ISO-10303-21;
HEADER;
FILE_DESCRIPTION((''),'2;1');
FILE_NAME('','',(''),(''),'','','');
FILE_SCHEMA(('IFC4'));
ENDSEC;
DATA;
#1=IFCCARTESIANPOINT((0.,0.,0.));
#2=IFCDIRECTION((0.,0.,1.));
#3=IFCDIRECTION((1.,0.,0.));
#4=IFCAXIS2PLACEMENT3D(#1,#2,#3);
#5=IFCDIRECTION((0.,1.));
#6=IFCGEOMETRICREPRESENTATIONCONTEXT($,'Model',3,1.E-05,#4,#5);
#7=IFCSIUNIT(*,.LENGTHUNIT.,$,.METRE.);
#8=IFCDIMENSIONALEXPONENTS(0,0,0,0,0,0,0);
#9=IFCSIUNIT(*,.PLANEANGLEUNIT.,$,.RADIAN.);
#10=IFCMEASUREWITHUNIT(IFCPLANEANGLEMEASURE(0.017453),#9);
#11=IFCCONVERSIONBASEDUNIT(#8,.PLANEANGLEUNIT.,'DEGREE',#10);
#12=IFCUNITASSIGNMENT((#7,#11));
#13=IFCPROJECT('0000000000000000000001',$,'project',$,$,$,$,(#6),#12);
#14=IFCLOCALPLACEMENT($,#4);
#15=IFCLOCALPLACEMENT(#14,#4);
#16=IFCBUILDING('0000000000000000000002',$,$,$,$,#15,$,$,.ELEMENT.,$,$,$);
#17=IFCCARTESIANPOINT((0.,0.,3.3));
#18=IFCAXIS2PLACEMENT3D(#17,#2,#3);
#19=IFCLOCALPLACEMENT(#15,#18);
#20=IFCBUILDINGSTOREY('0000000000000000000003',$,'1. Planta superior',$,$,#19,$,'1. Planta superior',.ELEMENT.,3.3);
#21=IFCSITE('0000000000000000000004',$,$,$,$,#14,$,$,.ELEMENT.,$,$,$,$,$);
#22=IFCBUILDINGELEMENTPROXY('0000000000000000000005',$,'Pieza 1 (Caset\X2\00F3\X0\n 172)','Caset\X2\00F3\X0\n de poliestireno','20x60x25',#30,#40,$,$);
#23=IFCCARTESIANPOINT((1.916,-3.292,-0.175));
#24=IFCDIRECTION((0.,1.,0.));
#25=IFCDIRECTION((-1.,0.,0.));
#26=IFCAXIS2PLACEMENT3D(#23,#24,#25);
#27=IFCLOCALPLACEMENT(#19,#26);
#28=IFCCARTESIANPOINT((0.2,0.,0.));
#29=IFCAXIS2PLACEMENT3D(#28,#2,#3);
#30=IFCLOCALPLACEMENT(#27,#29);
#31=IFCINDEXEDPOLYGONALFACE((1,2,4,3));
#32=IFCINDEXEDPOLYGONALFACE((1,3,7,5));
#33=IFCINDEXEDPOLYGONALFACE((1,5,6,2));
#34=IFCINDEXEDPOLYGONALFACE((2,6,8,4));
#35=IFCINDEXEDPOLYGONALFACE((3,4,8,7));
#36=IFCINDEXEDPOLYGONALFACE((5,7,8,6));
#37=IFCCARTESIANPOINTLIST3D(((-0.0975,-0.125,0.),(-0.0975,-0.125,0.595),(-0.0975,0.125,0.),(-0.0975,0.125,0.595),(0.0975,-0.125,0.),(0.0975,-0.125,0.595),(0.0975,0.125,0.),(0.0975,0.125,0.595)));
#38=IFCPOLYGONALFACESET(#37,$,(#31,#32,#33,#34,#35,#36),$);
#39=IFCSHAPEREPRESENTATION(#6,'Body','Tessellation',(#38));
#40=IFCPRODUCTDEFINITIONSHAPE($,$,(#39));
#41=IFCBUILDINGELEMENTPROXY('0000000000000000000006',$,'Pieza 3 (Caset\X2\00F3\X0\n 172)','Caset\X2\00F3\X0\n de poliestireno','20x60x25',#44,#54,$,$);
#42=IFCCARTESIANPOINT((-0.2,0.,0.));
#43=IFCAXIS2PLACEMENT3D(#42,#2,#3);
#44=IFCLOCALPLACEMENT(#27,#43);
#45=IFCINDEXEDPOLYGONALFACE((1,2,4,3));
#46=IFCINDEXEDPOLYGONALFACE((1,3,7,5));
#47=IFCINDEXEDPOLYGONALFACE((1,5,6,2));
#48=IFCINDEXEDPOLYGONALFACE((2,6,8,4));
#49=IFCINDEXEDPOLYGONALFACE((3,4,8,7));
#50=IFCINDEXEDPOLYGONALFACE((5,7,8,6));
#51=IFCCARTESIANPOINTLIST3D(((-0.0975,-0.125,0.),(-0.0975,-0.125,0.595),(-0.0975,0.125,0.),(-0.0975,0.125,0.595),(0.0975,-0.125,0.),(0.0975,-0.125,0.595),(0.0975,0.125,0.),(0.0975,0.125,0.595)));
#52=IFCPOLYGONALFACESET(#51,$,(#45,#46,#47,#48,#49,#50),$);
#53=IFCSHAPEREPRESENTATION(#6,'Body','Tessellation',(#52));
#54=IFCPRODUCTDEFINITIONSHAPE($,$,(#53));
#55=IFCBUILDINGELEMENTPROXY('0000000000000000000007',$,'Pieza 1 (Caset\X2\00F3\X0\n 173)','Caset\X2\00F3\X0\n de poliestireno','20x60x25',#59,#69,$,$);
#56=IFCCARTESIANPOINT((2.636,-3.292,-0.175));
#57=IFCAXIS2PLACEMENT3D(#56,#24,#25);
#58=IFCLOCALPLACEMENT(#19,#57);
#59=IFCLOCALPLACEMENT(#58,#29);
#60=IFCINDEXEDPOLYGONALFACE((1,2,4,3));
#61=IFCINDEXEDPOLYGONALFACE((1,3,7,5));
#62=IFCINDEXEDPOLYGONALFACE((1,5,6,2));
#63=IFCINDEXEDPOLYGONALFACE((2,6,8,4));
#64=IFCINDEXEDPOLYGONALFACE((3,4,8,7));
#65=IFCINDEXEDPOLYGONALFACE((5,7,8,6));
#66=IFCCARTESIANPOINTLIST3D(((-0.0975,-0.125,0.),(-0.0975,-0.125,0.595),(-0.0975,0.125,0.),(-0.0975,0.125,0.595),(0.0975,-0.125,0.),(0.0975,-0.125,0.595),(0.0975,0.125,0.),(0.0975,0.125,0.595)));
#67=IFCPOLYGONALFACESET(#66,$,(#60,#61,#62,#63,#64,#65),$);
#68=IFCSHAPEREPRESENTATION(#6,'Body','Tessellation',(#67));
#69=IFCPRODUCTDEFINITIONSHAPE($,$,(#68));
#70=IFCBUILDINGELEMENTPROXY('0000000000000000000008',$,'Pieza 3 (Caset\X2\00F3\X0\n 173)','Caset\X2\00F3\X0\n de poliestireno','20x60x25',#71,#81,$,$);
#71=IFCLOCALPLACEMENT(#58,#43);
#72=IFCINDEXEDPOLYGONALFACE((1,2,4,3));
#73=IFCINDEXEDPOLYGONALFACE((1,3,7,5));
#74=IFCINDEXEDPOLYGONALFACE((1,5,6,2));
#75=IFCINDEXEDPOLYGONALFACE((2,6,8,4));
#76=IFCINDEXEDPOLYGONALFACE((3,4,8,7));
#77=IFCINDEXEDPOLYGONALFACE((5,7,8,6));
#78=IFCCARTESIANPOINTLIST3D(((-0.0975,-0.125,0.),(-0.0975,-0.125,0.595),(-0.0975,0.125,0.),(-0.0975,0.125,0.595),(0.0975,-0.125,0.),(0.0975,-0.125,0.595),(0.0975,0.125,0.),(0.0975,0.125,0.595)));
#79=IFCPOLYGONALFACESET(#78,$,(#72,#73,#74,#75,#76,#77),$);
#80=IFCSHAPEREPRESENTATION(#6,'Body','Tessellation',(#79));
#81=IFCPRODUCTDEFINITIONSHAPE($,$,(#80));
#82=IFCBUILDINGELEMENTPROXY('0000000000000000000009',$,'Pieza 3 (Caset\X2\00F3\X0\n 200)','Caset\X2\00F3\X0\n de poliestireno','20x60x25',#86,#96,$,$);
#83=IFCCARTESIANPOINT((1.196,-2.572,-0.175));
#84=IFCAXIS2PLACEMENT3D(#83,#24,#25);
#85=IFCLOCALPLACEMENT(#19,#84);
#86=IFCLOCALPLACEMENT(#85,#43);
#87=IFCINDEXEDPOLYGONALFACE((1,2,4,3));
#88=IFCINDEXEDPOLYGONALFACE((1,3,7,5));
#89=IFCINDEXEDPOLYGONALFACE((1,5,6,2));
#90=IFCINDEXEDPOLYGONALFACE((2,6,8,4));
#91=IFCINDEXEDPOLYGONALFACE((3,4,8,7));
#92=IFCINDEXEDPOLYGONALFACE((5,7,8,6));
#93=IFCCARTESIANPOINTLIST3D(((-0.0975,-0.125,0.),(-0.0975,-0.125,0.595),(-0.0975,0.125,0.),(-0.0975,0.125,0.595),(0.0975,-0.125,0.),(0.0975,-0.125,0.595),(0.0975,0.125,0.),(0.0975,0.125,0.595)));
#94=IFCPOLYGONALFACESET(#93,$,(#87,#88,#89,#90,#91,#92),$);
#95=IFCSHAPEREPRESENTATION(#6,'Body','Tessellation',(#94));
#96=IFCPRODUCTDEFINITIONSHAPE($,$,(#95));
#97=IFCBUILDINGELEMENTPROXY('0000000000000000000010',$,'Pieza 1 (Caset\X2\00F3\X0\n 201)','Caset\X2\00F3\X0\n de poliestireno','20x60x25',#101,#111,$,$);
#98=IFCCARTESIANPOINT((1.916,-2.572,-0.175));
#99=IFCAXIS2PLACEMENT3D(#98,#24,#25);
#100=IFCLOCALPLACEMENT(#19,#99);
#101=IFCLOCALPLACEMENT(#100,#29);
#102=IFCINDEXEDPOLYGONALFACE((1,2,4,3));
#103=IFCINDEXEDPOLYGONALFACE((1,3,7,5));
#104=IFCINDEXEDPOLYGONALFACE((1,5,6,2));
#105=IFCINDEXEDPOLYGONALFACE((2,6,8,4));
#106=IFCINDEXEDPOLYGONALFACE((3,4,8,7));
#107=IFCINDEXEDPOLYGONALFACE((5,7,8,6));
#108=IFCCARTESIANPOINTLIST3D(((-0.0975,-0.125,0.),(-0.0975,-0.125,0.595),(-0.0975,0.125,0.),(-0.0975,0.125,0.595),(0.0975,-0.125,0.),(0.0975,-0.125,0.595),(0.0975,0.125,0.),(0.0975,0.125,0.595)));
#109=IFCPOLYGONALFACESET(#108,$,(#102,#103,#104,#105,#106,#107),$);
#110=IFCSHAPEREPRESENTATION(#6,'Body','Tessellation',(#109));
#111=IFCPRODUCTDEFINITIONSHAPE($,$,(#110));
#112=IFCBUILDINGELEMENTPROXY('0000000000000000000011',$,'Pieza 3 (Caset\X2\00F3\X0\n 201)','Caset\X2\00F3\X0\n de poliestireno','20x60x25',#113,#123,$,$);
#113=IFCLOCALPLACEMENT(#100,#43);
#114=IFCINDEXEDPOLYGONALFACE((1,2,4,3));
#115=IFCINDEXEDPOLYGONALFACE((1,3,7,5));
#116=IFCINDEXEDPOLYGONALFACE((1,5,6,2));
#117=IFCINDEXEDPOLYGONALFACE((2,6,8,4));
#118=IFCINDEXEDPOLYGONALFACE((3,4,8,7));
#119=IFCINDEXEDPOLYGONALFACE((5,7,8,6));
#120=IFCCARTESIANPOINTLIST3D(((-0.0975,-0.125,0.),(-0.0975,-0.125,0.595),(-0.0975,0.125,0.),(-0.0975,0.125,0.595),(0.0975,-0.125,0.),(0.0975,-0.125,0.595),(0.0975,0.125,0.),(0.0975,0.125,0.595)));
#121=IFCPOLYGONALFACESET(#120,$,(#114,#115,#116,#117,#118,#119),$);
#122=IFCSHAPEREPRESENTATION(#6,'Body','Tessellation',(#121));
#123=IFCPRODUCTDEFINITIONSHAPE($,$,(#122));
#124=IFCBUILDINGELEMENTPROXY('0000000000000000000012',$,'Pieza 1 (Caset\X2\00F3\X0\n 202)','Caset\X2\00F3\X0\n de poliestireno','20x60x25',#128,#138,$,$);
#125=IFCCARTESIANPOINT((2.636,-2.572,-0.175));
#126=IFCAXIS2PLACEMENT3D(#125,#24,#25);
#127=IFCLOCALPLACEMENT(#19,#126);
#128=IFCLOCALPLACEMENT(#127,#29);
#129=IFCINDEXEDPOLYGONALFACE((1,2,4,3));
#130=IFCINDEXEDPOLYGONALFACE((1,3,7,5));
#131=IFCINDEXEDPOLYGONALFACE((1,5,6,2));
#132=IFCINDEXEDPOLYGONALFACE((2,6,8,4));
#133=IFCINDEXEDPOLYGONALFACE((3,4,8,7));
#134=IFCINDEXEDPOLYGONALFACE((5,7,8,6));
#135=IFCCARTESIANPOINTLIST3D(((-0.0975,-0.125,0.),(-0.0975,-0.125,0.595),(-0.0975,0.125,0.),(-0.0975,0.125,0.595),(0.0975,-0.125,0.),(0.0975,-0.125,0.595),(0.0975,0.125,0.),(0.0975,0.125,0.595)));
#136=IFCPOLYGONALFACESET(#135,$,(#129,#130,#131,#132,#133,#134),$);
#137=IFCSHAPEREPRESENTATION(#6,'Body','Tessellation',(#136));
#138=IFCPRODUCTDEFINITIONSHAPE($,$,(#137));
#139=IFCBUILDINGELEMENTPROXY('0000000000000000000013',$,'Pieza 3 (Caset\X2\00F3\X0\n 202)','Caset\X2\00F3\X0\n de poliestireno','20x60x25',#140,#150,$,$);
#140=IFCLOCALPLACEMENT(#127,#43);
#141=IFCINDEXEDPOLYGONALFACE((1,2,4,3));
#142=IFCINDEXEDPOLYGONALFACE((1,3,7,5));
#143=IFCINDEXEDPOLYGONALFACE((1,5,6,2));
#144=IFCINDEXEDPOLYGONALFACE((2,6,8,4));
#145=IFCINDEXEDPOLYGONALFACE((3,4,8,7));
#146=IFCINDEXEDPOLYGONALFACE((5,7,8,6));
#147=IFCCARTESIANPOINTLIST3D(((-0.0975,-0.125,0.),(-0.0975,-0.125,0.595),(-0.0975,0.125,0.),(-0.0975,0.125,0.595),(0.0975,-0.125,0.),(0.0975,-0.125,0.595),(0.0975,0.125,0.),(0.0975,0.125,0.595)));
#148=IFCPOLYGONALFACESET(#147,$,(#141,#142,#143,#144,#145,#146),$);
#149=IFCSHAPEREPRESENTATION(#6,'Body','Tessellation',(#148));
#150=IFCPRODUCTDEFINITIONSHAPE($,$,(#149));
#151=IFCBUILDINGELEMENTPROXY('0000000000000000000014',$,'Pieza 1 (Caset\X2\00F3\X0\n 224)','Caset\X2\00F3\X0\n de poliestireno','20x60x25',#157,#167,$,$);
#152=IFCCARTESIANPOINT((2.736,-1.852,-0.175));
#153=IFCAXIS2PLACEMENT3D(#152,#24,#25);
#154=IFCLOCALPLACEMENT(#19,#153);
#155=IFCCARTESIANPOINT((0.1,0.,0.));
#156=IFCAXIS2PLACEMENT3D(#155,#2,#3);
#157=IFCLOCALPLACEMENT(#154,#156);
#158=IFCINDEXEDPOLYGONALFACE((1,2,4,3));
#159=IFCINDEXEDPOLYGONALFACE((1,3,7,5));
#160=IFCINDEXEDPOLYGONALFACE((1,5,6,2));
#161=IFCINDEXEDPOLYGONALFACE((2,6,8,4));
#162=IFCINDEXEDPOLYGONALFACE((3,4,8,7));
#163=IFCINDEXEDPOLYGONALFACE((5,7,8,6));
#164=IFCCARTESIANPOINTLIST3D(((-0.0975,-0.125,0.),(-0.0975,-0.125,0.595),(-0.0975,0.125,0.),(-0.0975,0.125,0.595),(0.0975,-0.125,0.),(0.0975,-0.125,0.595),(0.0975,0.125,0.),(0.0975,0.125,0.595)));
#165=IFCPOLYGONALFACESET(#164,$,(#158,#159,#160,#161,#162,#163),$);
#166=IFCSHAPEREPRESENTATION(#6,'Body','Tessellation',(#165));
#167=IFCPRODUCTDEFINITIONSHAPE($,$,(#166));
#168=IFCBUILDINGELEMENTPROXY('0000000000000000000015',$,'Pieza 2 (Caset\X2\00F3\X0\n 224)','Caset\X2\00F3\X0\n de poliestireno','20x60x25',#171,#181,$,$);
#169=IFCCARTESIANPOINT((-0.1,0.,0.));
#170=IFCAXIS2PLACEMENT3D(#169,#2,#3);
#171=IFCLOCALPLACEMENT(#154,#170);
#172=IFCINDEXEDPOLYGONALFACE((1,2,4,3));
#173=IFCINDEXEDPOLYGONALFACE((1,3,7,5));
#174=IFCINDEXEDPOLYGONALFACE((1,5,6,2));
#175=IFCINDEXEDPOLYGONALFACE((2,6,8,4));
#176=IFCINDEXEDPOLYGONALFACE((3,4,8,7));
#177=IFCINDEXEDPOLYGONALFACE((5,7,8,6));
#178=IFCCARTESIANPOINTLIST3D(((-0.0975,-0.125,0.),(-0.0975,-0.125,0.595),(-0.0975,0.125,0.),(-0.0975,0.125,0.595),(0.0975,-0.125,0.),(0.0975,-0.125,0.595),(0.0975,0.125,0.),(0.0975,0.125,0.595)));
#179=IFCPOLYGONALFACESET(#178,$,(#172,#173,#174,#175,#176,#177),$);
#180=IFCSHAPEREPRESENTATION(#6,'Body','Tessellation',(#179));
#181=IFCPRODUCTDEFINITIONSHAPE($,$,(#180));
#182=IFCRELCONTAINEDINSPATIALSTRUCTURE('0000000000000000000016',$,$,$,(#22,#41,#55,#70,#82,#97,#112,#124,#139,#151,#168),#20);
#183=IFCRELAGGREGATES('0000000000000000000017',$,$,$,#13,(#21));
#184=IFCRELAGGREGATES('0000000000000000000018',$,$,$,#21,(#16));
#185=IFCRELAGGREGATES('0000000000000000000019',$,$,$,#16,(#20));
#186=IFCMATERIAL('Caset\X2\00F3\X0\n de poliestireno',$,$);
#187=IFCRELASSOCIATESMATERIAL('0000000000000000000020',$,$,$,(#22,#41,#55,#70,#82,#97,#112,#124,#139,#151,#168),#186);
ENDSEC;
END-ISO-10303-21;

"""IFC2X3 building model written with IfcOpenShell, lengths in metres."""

from ifc_helpers import new_model, entity, si_unit, converted_unit, direction, frame, origin_with_axes, origin_2d_with_axis, place, context, project, spatial, rectangle, extrude, source, transform, mapped, material, element, save


model = new_model("IFC2X3")

# Units and contexts
model_context = context("Model", 3, precision=1e-05, world=origin_with_axes(), true_north=direction((0.0, 1.0)))
ifc_project = project(units=[si_unit("LENGTHUNIT", "METRE"), converted_unit("PLANEANGLEUNIT", "DEGREE", entity("IfcPlaneAngleMeasure", 0.017453), si_unit("PLANEANGLEUNIT", "RADIAN"), dimensions=[0, 0, 0, 0, 0, 0, 0])], contexts=[model_context])

# Site, building, storey
site_placement = place(None, origin_with_axes())
site = spatial("IfcSite", under=ifc_project, at=site_placement, CompositionType="ELEMENT")
building_placement = place(site_placement, origin_with_axes())
building = spatial("IfcBuilding", under=site, at=building_placement, CompositionType="ELEMENT")
storey_placement = place(building_placement, frame((0.0, 0.0, 3.3), z_axis=(0.0, 0.0, 1.0), x_axis=(1.0, 0.0, 0.0)))
storey = spatial("IfcBuildingStorey", under=building, at=storey_placement, Name="1. Planta superior", LongName="1. Planta superior", CompositionType="ELEMENT", Elevation=3.3)

# Building element proxies
ifc_material_1 = material(Name="Casetón de poliestireno")
shared_shape = source(origin_with_axes(), model_context, "Body", "SweptSolid", [
    extrude(rectangle(XDim=0.195, YDim=0.25, at=origin_2d_with_axis()), origin_with_axes(), (0.0, 0.0, 1.0), 0.595),
])
placement_1 = place(storey_placement, frame((1.916, -3.292, -0.175), z_axis=(0.0, 1.0, 0.0), x_axis=(-1.0, 0.0, 0.0)))
for number, where, z_axis, x_axis, name in (
    (1, (0.2, 0.0, 0.0), (0.0, 0.0, 1.0), (1.0, 0.0, 0.0), "Pieza 1 (Casetón 172)"),
    (2, (-0.2, 0.0, 0.0), (0.0, 0.0, 1.0), (1.0, 0.0, 0.0), "Pieza 3 (Casetón 172)"),
):
    element("IfcBuildingElementProxy", number, at=place(placement_1, frame(where, z_axis=z_axis, x_axis=x_axis)), inside=storey, material=ifc_material_1, Name=name, Description="Casetón de poliestireno", ObjectType="20x60x25", context=model_context, shape_type="MappedRepresentation", body=[
        mapped(shared_shape, transform((0.0, 0.0, 0.0), x_axis=(1.0, 0.0, 0.0), y_axis=(0.0, 1.0, 0.0), z_axis=(0.0, 0.0, 1.0))),
    ])
placement_2 = place(storey_placement, frame((2.636, -3.292, -0.175), z_axis=(0.0, 1.0, 0.0), x_axis=(-1.0, 0.0, 0.0)))
for number, where, z_axis, x_axis, name in (
    (3, (0.2, 0.0, 0.0), (0.0, 0.0, 1.0), (1.0, 0.0, 0.0), "Pieza 1 (Casetón 173)"),
    (4, (-0.2, 0.0, 0.0), (0.0, 0.0, 1.0), (1.0, 0.0, 0.0), "Pieza 3 (Casetón 173)"),
):
    element("IfcBuildingElementProxy", number, at=place(placement_2, frame(where, z_axis=z_axis, x_axis=x_axis)), inside=storey, material=ifc_material_1, Name=name, Description="Casetón de poliestireno", ObjectType="20x60x25", context=model_context, shape_type="MappedRepresentation", body=[
        mapped(shared_shape, transform((0.0, 0.0, 0.0), x_axis=(1.0, 0.0, 0.0), y_axis=(0.0, 1.0, 0.0), z_axis=(0.0, 0.0, 1.0))),
    ])
placement_3 = place(storey_placement, frame((1.196, -2.572, -0.175), z_axis=(0.0, 1.0, 0.0), x_axis=(-1.0, 0.0, 0.0)))
for number, where, z_axis, x_axis, name in (
    (5, (-0.2, 0.0, 0.0), (0.0, 0.0, 1.0), (1.0, 0.0, 0.0), "Pieza 3 (Casetón 200)"),
):
    element("IfcBuildingElementProxy", number, at=place(placement_3, frame(where, z_axis=z_axis, x_axis=x_axis)), inside=storey, material=ifc_material_1, Name=name, Description="Casetón de poliestireno", ObjectType="20x60x25", context=model_context, shape_type="MappedRepresentation", body=[
        mapped(shared_shape, transform((0.0, 0.0, 0.0), x_axis=(1.0, 0.0, 0.0), y_axis=(0.0, 1.0, 0.0), z_axis=(0.0, 0.0, 1.0))),
    ])
placement_4 = place(storey_placement, frame((1.916, -2.572, -0.175), z_axis=(0.0, 1.0, 0.0), x_axis=(-1.0, 0.0, 0.0)))
for number, where, z_axis, x_axis, name in (
    (6, (0.2, 0.0, 0.0), (0.0, 0.0, 1.0), (1.0, 0.0, 0.0), "Pieza 1 (Casetón 201)"),
    (7, (-0.2, 0.0, 0.0), (0.0, 0.0, 1.0), (1.0, 0.0, 0.0), "Pieza 3 (Casetón 201)"),
):
    element("IfcBuildingElementProxy", number, at=place(placement_4, frame(where, z_axis=z_axis, x_axis=x_axis)), inside=storey, material=ifc_material_1, Name=name, Description="Casetón de poliestireno", ObjectType="20x60x25", context=model_context, shape_type="MappedRepresentation", body=[
        mapped(shared_shape, transform((0.0, 0.0, 0.0), x_axis=(1.0, 0.0, 0.0), y_axis=(0.0, 1.0, 0.0), z_axis=(0.0, 0.0, 1.0))),
    ])
placement_5 = place(storey_placement, frame((2.636, -2.572, -0.175), z_axis=(0.0, 1.0, 0.0), x_axis=(-1.0, 0.0, 0.0)))
for number, where, z_axis, x_axis, name in (
    (8, (0.2, 0.0, 0.0), (0.0, 0.0, 1.0), (1.0, 0.0, 0.0), "Pieza 1 (Casetón 202)"),
    (9, (-0.2, 0.0, 0.0), (0.0, 0.0, 1.0), (1.0, 0.0, 0.0), "Pieza 3 (Casetón 202)"),
):
    element("IfcBuildingElementProxy", number, at=place(placement_5, frame(where, z_axis=z_axis, x_axis=x_axis)), inside=storey, material=ifc_material_1, Name=name, Description="Casetón de poliestireno", ObjectType="20x60x25", context=model_context, shape_type="MappedRepresentation", body=[
        mapped(shared_shape, transform((0.0, 0.0, 0.0), x_axis=(1.0, 0.0, 0.0), y_axis=(0.0, 1.0, 0.0), z_axis=(0.0, 0.0, 1.0))),
    ])
placement_6 = place(storey_placement, frame((2.736, -1.852, -0.175), z_axis=(0.0, 1.0, 0.0), x_axis=(-1.0, 0.0, 0.0)))
for number, where, z_axis, x_axis, name in (
    (10, (0.1, 0.0, 0.0), (0.0, 0.0, 1.0), (1.0, 0.0, 0.0), "Pieza 1 (Casetón 224)"),
    (11, (-0.1, 0.0, 0.0), (0.0, 0.0, 1.0), (1.0, 0.0, 0.0), "Pieza 2 (Casetón 224)"),
):
    element("IfcBuildingElementProxy", number, at=place(placement_6, frame(where, z_axis=z_axis, x_axis=x_axis)), inside=storey, material=ifc_material_1, Name=name, Description="Casetón de poliestireno", ObjectType="20x60x25", context=model_context, shape_type="MappedRepresentation", body=[
        mapped(shared_shape, transform((0.0, 0.0, 0.0), x_axis=(1.0, 0.0, 0.0), y_axis=(0.0, 1.0, 0.0), z_axis=(0.0, 0.0, 1.0))),
    ])

save(model, "model.ifc")
